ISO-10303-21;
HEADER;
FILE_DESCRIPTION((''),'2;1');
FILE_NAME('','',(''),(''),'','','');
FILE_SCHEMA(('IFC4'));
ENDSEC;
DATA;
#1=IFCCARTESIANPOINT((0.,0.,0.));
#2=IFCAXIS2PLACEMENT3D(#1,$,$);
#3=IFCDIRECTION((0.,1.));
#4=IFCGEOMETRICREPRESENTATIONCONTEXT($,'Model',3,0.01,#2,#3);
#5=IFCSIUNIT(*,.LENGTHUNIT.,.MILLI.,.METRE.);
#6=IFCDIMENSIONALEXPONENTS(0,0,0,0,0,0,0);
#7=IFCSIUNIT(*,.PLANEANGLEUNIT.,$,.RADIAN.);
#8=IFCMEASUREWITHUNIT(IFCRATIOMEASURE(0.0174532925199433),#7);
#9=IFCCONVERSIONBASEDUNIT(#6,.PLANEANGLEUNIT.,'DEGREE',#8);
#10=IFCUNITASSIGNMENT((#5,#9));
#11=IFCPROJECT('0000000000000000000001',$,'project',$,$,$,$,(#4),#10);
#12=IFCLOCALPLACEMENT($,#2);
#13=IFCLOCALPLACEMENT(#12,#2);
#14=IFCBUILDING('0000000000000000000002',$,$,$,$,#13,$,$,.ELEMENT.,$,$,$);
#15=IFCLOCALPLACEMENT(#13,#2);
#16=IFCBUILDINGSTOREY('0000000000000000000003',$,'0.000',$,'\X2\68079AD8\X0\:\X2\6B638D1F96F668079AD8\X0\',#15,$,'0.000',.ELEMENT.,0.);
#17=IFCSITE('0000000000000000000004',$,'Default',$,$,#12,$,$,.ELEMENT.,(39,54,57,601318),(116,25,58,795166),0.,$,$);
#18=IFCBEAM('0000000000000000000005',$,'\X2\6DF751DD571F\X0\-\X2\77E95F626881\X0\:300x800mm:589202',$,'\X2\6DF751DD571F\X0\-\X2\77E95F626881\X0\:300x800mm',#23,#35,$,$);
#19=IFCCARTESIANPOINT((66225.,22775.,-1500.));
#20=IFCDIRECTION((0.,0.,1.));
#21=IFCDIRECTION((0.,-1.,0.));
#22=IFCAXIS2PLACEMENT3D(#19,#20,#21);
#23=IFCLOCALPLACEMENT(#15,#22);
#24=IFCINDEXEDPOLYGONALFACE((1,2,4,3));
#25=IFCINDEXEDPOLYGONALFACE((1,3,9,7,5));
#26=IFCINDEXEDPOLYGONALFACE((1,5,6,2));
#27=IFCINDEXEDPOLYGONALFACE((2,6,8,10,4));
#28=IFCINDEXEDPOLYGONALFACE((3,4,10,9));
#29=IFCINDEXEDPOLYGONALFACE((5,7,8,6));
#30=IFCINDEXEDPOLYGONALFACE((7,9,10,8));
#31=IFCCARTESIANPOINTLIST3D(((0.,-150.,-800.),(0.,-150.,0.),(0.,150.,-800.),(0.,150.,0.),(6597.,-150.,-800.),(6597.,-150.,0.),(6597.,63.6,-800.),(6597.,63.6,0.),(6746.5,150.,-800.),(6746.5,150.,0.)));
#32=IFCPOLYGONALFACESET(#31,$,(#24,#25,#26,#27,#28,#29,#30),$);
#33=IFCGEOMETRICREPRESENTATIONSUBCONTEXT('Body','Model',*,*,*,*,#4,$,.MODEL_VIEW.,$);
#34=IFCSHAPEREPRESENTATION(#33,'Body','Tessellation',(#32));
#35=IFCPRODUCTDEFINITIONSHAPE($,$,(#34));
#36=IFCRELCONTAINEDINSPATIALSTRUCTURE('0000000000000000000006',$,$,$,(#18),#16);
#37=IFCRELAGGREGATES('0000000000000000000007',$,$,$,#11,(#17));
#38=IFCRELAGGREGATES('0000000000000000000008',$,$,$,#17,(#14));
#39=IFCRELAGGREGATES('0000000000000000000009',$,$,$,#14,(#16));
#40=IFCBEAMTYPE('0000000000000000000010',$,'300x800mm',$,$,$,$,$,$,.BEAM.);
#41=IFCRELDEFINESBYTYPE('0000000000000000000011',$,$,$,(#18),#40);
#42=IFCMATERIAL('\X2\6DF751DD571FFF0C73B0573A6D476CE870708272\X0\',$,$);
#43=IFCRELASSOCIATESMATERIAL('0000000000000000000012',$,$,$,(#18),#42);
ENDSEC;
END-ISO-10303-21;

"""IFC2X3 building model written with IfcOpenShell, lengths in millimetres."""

from ifc_helpers import new_model, entity, si_unit, converted_unit, direction, frame, frame_2d, origin, place, context, subcontext, project, spatial, polyline, rectangle, extrude, clip, bounded_halfspace, material, type_object, element, save


model = new_model("IFC2X3")

# Units and contexts
model_context = context("Model", 3, precision=0.01, world=origin(), true_north=direction((0.0, 1.0)))
body_context = subcontext(model_context, "Body", "Model", "MODEL_VIEW")
ifc_project = project(units=[si_unit("LENGTHUNIT", "METRE", prefix="MILLI"), converted_unit("PLANEANGLEUNIT", "DEGREE", entity("IfcRatioMeasure", 0.0174532925199433), si_unit("PLANEANGLEUNIT", "RADIAN"), dimensions=[0, 0, 0, 0, 0, 0, 0])], contexts=[model_context])

# Site, building, storey
site_placement = place(None, origin())
site = spatial("IfcSite", under=ifc_project, at=site_placement, Name="Default", CompositionType="ELEMENT", RefLatitude=(39, 54, 57, 601318), RefLongitude=(116, 25, 58, 795166), RefElevation=0.0)
building_placement = place(site_placement, origin())
building = spatial("IfcBuilding", under=site, at=building_placement, CompositionType="ELEMENT")
storey_placement = place(building_placement, origin())
storey = spatial("IfcBuildingStorey", under=building, at=storey_placement, Name="0.000", ObjectType="标高:正负零标高", LongName="0.000", CompositionType="ELEMENT", Elevation=0.0)

# Shared definitions
ifc_material = material(Name="混凝土，现场浇注灰色")

# Beam
beam_type_1 = type_object("IfcBeamType", Name="300x800mm", PredefinedType="BEAM")
beam_1_placement = place(storey_placement, frame((66225.0, 22775.0, -1500.0), z_axis=(0.0, 0.0, 1.0), x_axis=(0.0, -1.0, 0.0)))
element("IfcBeam", 1, at=beam_1_placement, inside=storey, type_object=beam_type_1, material=ifc_material, Name="混凝土-矩形梁:300x800mm:589202", ObjectType="混凝土-矩形梁:300x800mm", context=body_context, shape_type="Clipping", body=[
    clip(clip(extrude(rectangle(XDim=800.0, YDim=300.0, at=frame_2d((0.0, 0.0), x_axis=(1.0, 0.0))), frame((0.0, 0.0, -400.0), z_axis=(1.0, 0.0, 0.0), x_axis=(0.0, 0.0, -1.0)), (0.0, 0.0, 1.0), 6746.5), bounded_halfspace(frame((9175.0, 1552.4, 0.0), z_axis=(0.500083, -0.865977, 0.0), x_axis=(0.0, 0.0, -1.0)), False, frame((0.0, 0.0, -400.0), z_axis=(1.0, 0.0, 0.0), x_axis=(0.0, 0.0, -1.0)), polyline([(-400.0, 63.6), (400.0, 63.6), (400.0, 150.0), (-400.0, 150.0), (-400.0, 63.6)]))), bounded_halfspace(frame((6597.0, 63.6, 0.0), z_axis=(1.0, 0.0, 0.0), x_axis=(0.0, 0.0, -1.0)), False, frame((0.0, 0.0, -400.0), z_axis=(1.0, 0.0, 0.0), x_axis=(0.0, 0.0, -1.0)), polyline([(400.0, 63.6), (-400.0, 63.6), (-400.0, -150.0), (400.0, -150.0), (400.0, 63.6)]))),
])

save(model, "model.ifc")
